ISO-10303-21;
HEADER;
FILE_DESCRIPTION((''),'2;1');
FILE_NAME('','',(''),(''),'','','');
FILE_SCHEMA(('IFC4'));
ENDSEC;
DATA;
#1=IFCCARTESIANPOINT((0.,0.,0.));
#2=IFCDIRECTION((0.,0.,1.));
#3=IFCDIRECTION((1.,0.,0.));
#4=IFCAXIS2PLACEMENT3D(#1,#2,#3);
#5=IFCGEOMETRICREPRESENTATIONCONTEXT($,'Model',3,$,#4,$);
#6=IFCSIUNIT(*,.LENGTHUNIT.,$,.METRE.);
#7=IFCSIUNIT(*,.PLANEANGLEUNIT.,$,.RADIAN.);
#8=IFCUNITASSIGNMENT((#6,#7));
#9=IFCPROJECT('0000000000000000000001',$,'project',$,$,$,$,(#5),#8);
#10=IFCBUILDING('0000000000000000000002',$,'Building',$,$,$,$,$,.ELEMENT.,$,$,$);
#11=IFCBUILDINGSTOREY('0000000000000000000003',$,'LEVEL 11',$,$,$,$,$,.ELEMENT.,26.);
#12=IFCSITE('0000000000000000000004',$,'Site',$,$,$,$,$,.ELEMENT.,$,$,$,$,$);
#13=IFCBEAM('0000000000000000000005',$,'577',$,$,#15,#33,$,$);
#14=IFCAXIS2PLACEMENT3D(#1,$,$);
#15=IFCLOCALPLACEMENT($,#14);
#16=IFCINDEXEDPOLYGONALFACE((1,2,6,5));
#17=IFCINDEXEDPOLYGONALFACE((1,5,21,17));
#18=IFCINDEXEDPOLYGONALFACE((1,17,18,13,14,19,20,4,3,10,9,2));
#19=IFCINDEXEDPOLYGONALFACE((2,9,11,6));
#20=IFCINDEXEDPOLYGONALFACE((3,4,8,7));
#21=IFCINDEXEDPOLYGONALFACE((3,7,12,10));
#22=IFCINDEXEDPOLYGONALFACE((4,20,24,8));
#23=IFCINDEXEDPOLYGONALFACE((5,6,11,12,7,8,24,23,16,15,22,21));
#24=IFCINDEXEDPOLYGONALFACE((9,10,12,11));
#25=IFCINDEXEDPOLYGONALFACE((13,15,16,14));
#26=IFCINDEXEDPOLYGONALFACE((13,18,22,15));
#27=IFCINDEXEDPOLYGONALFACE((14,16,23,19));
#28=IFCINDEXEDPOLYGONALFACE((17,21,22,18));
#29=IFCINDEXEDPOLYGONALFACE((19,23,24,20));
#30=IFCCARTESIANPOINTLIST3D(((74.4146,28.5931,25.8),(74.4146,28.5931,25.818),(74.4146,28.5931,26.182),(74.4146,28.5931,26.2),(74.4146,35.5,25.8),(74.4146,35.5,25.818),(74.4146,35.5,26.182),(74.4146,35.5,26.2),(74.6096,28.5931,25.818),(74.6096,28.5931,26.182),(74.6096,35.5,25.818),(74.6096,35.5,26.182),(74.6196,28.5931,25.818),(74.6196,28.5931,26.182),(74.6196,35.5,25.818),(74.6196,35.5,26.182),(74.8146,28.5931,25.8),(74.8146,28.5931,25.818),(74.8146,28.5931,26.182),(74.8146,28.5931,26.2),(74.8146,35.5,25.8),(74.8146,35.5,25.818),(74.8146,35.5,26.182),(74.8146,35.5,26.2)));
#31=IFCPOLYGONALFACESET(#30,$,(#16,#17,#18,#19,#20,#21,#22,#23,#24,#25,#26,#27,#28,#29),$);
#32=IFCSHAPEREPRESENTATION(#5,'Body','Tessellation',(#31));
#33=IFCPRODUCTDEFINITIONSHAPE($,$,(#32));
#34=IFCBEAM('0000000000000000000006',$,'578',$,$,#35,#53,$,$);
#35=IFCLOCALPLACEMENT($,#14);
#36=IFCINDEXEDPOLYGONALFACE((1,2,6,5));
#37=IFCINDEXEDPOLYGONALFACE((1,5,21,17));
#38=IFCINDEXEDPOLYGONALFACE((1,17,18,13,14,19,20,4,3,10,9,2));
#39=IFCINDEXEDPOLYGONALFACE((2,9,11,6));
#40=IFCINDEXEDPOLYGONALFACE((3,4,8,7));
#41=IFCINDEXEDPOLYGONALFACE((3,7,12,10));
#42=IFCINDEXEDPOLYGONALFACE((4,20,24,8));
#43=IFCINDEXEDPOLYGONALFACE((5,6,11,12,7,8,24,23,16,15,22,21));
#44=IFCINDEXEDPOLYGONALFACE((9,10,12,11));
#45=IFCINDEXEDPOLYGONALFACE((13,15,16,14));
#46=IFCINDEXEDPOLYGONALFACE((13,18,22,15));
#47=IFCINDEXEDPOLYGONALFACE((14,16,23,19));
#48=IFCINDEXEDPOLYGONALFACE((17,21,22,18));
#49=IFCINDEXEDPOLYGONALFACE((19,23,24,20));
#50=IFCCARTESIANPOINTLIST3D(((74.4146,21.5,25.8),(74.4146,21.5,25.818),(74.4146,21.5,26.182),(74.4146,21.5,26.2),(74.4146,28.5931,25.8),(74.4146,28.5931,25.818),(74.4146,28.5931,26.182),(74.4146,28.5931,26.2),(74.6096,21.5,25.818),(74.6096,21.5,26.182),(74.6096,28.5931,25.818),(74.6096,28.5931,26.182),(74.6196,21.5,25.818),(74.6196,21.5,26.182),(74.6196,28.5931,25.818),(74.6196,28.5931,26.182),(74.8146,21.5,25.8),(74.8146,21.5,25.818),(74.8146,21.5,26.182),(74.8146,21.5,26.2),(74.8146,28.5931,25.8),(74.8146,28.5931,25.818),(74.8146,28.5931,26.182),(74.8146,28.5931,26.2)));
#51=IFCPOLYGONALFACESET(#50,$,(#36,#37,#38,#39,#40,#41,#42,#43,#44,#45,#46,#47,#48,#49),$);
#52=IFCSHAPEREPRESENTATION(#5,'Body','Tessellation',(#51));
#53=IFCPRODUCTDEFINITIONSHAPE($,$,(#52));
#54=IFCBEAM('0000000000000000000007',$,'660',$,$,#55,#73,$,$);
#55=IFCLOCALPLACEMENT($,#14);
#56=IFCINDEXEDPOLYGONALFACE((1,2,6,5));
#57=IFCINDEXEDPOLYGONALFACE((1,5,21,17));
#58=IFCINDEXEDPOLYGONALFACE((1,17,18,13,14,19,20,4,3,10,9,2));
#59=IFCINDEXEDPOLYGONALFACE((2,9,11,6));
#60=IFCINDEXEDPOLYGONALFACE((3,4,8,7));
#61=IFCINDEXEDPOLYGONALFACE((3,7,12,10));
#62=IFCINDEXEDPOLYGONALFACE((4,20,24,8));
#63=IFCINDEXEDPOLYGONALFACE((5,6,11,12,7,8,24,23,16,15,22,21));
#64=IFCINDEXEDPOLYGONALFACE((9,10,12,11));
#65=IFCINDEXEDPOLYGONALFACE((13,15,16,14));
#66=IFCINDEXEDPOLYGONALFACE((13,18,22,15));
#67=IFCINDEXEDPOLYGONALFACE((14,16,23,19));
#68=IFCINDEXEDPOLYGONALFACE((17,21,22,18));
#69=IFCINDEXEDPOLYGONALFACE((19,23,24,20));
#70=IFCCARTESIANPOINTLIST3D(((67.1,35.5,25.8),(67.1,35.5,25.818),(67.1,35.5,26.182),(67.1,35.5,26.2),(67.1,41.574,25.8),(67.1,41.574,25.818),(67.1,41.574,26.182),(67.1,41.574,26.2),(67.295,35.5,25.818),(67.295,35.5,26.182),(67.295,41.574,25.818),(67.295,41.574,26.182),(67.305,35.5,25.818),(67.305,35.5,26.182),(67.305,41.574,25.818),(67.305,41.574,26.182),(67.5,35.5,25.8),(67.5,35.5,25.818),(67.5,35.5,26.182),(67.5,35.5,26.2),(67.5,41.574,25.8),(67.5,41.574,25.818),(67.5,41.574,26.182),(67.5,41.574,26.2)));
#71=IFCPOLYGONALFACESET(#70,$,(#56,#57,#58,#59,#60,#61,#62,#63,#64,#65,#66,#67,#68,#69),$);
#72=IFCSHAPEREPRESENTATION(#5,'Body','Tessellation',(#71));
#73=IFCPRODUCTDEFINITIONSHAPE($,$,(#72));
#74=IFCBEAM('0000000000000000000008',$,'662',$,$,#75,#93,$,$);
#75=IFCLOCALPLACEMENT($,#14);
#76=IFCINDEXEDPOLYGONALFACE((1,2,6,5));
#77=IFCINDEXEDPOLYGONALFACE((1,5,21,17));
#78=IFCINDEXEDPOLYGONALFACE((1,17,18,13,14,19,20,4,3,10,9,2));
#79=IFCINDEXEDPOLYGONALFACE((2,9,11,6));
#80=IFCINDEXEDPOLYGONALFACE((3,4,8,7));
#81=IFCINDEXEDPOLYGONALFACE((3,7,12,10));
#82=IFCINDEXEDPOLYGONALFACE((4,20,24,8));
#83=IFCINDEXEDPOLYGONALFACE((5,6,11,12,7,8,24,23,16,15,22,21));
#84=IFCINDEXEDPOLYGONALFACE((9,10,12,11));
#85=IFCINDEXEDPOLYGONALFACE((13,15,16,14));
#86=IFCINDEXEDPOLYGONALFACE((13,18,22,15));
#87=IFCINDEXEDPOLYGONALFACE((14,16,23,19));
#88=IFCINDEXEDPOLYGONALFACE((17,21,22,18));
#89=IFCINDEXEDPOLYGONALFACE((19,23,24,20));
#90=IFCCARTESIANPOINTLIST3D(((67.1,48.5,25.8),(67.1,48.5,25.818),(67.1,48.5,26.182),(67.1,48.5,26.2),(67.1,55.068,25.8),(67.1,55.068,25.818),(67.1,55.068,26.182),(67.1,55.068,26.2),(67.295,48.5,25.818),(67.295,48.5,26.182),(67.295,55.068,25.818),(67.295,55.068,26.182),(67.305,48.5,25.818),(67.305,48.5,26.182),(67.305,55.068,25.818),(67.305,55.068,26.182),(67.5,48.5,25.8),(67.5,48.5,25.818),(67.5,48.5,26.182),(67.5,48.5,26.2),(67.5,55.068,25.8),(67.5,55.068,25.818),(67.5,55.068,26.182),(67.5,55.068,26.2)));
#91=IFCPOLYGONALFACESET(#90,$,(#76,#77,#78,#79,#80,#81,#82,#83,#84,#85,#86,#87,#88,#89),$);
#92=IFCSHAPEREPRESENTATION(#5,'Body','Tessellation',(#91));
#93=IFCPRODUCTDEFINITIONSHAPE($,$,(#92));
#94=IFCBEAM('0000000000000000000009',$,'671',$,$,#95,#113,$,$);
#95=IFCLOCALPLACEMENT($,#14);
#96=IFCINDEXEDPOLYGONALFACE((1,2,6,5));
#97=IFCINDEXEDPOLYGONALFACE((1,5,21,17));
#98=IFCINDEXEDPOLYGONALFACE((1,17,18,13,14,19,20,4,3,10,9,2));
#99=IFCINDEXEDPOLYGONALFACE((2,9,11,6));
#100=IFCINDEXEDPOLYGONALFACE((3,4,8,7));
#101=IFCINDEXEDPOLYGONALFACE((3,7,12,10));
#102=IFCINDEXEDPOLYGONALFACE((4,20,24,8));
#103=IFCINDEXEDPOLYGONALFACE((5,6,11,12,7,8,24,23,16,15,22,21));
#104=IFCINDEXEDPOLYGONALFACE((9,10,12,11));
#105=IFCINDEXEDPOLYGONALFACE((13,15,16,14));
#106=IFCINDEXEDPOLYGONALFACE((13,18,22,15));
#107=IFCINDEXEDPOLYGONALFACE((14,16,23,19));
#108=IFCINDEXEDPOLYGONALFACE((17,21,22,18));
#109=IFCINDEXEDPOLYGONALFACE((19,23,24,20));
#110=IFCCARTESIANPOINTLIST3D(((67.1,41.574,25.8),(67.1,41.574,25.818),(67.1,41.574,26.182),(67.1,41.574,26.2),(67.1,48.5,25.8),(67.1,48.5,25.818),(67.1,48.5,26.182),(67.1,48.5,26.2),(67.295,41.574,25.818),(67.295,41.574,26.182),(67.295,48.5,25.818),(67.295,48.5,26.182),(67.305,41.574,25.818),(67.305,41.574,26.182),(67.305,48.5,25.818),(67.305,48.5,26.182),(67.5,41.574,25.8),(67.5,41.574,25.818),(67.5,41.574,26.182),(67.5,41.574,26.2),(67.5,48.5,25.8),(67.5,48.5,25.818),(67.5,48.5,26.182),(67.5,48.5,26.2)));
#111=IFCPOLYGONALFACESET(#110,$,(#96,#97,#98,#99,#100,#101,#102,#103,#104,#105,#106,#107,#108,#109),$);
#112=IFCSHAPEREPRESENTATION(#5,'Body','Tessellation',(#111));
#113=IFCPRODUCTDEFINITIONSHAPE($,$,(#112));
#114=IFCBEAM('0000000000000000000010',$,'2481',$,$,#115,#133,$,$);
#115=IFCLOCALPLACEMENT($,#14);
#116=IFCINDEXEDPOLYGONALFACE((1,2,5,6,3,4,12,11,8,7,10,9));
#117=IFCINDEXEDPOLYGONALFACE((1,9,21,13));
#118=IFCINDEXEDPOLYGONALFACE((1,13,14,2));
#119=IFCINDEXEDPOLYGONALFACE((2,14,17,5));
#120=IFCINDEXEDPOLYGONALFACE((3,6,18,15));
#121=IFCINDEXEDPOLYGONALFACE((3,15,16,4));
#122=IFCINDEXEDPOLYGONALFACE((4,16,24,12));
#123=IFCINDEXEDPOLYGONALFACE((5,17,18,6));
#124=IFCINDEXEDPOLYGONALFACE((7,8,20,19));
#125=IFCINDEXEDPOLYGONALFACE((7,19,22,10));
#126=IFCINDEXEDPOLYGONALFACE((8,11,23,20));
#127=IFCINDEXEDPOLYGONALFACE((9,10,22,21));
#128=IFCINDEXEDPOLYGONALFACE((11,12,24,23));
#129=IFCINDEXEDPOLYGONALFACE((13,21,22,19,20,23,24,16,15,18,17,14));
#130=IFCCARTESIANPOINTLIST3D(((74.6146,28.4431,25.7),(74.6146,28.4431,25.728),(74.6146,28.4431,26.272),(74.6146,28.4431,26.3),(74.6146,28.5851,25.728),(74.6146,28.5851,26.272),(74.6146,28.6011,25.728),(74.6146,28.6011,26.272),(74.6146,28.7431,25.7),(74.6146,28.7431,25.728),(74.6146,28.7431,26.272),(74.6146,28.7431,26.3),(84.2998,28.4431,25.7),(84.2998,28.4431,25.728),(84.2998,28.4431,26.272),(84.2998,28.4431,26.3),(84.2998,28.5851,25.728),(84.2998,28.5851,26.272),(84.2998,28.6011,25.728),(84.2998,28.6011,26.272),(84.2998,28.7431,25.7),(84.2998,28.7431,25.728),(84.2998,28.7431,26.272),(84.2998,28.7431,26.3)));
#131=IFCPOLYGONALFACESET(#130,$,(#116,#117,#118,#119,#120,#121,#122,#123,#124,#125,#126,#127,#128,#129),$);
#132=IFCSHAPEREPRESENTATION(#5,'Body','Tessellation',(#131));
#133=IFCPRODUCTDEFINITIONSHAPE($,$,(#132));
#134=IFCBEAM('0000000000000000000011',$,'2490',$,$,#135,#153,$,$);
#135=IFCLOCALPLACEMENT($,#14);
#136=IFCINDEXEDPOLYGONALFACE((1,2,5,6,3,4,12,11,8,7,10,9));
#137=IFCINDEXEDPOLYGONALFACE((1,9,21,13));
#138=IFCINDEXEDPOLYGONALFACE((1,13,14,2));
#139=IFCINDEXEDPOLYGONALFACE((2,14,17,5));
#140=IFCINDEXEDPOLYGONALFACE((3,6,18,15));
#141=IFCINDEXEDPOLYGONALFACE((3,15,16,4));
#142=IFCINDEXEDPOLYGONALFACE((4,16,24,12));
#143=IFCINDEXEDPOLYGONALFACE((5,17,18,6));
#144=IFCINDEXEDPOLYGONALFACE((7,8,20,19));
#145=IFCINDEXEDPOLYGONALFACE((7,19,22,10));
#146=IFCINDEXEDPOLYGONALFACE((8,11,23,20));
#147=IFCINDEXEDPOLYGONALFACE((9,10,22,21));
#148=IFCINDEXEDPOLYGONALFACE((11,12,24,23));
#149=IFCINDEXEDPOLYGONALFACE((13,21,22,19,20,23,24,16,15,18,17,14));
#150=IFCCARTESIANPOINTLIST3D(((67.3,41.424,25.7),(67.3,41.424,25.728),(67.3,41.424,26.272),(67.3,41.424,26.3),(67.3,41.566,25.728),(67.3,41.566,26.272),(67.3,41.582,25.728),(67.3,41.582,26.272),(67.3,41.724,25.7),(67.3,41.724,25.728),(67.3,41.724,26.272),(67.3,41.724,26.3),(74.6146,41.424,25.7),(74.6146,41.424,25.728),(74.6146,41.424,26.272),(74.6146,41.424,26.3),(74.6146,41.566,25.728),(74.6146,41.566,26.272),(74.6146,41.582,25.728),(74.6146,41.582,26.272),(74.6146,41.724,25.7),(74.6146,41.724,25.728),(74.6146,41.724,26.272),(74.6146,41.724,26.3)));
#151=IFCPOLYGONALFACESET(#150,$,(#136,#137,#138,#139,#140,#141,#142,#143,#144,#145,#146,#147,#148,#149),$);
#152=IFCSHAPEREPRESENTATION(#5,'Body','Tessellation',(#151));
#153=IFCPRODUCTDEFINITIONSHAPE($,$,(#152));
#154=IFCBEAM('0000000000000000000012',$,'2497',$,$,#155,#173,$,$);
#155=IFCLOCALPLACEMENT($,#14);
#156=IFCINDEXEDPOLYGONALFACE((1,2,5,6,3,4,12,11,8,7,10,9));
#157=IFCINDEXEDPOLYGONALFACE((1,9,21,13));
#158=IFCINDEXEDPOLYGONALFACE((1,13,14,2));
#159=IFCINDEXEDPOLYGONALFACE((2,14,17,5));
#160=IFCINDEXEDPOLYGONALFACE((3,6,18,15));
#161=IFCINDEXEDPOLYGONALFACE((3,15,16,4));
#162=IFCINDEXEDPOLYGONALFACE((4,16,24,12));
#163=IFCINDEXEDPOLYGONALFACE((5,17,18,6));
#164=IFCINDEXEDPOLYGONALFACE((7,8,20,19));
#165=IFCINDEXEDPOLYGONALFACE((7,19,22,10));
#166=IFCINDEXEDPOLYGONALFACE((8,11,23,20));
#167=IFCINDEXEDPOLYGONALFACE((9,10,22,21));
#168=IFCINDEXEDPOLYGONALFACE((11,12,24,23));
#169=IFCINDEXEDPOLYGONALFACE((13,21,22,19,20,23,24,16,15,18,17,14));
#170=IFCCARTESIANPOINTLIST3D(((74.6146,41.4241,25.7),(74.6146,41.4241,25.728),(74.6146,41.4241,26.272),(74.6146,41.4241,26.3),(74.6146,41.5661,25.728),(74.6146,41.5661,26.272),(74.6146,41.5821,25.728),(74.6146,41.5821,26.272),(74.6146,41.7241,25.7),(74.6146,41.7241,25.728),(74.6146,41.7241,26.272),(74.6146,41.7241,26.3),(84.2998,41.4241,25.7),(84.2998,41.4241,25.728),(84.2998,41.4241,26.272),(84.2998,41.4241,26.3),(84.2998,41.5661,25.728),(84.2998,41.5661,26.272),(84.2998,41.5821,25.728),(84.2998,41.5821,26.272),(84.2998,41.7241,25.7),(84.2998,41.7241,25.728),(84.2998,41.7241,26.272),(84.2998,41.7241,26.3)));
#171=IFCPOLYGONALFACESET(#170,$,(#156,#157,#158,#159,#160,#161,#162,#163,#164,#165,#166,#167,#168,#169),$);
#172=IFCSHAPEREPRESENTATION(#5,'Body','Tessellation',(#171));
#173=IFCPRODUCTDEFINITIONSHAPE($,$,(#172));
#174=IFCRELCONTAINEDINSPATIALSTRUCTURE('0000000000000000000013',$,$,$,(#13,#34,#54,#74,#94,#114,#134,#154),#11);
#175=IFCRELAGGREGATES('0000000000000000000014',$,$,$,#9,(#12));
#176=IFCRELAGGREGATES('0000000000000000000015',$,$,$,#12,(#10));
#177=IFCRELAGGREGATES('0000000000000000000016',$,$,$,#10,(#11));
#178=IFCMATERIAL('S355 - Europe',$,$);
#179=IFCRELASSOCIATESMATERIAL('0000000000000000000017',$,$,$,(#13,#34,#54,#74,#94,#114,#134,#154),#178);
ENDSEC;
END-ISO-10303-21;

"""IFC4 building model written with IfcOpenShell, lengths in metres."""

from ifc_helpers import new_model, si_unit, frame, origin_with_axes, origin_2d_with_axis, place, context, project, spatial, i_section, extrude, material, material_profile, profile_set, profile_usage, element, save


model = new_model("IFC4")

# Units and contexts
model_context = context("Model", 3, world=origin_with_axes())
ifc_project = project(units=[si_unit("LENGTHUNIT", "METRE"), si_unit("PLANEANGLEUNIT", "RADIAN")], contexts=[model_context])

# Site, building, storey
site = spatial("IfcSite", under=ifc_project, Name="Site", CompositionType="ELEMENT")
building = spatial("IfcBuilding", under=site, Name="Building", CompositionType="ELEMENT")
storey = spatial("IfcBuildingStorey", under=building, Name="LEVEL 11", CompositionType="ELEMENT", Elevation=26.0)

# Shared definitions
ifc_material = material(Name="S355 - Europe")

# Beams
ifc_material_profile_1 = material_profile(ifc_material, i_section(OverallWidth=0.4, OverallDepth=0.4, WebThickness=0.01, FlangeThickness=0.018, at=origin_2d_with_axis()))
ifc_profile_set_1 = profile_set([ifc_material_profile_1])
ifc_profile_usage_1 = profile_usage(ifc_profile_set_1, cardinal=10)
beam_1_placement = place(None, frame((74.6146, 35.5, 26.0), z_axis=(0.0, -1.0, 0.0), x_axis=(1.0, 0.0, 0.0)))
element("IfcBeam", 1, at=beam_1_placement, inside=storey, material=ifc_profile_usage_1, Name="577", context=model_context, shape_type="SweptSolid", body=[
    extrude(i_section(OverallWidth=0.4, OverallDepth=0.4, WebThickness=0.01, FlangeThickness=0.018, at=origin_2d_with_axis()), origin_with_axes(), (0.0, 0.0, 1.0), 6.9069),
])
ifc_material_profile_2 = material_profile(ifc_material, i_section(OverallWidth=0.4, OverallDepth=0.4, WebThickness=0.01, FlangeThickness=0.018, at=origin_2d_with_axis()))
ifc_profile_set_2 = profile_set([ifc_material_profile_2])
ifc_profile_usage_2 = profile_usage(ifc_profile_set_2, cardinal=10)
beam_2_placement = place(None, frame((74.6146, 28.5931, 26.0), z_axis=(0.0, -1.0, 0.0), x_axis=(1.0, 0.0, 0.0)))
element("IfcBeam", 2, at=beam_2_placement, inside=storey, material=ifc_profile_usage_2, Name="578", context=model_context, shape_type="SweptSolid", body=[
    extrude(i_section(OverallWidth=0.4, OverallDepth=0.4, WebThickness=0.01, FlangeThickness=0.018, at=origin_2d_with_axis()), origin_with_axes(), (0.0, 0.0, 1.0), 7.0931),
])
ifc_material_profile_3 = material_profile(ifc_material, i_section(OverallWidth=0.4, OverallDepth=0.4, WebThickness=0.01, FlangeThickness=0.018, at=origin_2d_with_axis()))
ifc_profile_set_3 = profile_set([ifc_material_profile_3])
ifc_profile_usage_3 = profile_usage(ifc_profile_set_3, cardinal=10)
beam_3_placement = place(None, frame((67.3, 35.5, 26.0), z_axis=(0.0, 1.0, 0.0), x_axis=(-1.0, 0.0, 0.0)))
element("IfcBeam", 3, at=beam_3_placement, inside=storey, material=ifc_profile_usage_3, Name="660", context=model_context, shape_type="SweptSolid", body=[
    extrude(i_section(OverallWidth=0.4, OverallDepth=0.4, WebThickness=0.01, FlangeThickness=0.018, at=origin_2d_with_axis()), origin_with_axes(), (0.0, 0.0, 1.0), 6.074),
])
ifc_material_profile_4 = material_profile(ifc_material, i_section(OverallWidth=0.4, OverallDepth=0.4, WebThickness=0.01, FlangeThickness=0.018, at=origin_2d_with_axis()))
ifc_profile_set_4 = profile_set([ifc_material_profile_4])
ifc_profile_usage_4 = profile_usage(ifc_profile_set_4, cardinal=10)
beam_4_placement = place(None, frame((67.3, 48.5, 26.0), z_axis=(0.0, 1.0, 0.0), x_axis=(-1.0, 0.0, 0.0)))
element("IfcBeam", 4, at=beam_4_placement, inside=storey, material=ifc_profile_usage_4, Name="662", context=model_context, shape_type="SweptSolid", body=[
    extrude(i_section(OverallWidth=0.4, OverallDepth=0.4, WebThickness=0.01, FlangeThickness=0.018, at=origin_2d_with_axis()), origin_with_axes(), (0.0, 0.0, 1.0), 6.568),
])
ifc_material_profile_5 = material_profile(ifc_material, i_section(OverallWidth=0.4, OverallDepth=0.4, WebThickness=0.01, FlangeThickness=0.018, at=origin_2d_with_axis()))
ifc_profile_set_5 = profile_set([ifc_material_profile_5])
ifc_profile_usage_5 = profile_usage(ifc_profile_set_5, cardinal=10)
beam_5_placement = place(None, frame((67.3, 41.574, 26.0), z_axis=(0.0, 1.0, 0.0), x_axis=(-1.0, 0.0, 0.0)))
element("IfcBeam", 5, at=beam_5_placement, inside=storey, material=ifc_profile_usage_5, Name="671", context=model_context, shape_type="SweptSolid", body=[
    extrude(i_section(OverallWidth=0.4, OverallDepth=0.4, WebThickness=0.01, FlangeThickness=0.018, at=origin_2d_with_axis()), origin_with_axes(), (0.0, 0.0, 1.0), 6.926),
])
ifc_material_profile_6 = material_profile(ifc_material, i_section(OverallWidth=0.3, OverallDepth=0.6, WebThickness=0.016, FlangeThickness=0.028, at=origin_2d_with_axis()))
ifc_profile_set_6 = profile_set([ifc_material_profile_6])
ifc_profile_usage_6 = profile_usage(ifc_profile_set_6, cardinal=10)
beam_6_placement = place(None, frame((74.6146, 28.5931, 26.0), z_axis=(1.0, 0.0, 0.0), x_axis=(0.0, 1.0, 0.0)))
element("IfcBeam", 6, at=beam_6_placement, inside=storey, material=ifc_profile_usage_6, Name="2481", context=model_context, shape_type="SweptSolid", body=[
    extrude(i_section(OverallWidth=0.3, OverallDepth=0.6, WebThickness=0.016, FlangeThickness=0.028, at=origin_2d_with_axis()), origin_with_axes(), (0.0, 0.0, 1.0), 9.6852),
])
ifc_material_profile_7 = material_profile(ifc_material, i_section(OverallWidth=0.3, OverallDepth=0.6, WebThickness=0.016, FlangeThickness=0.028, at=origin_2d_with_axis()))
ifc_profile_set_7 = profile_set([ifc_material_profile_7])
ifc_profile_usage_7 = profile_usage(ifc_profile_set_7, cardinal=10)
beam_7_placement = place(None, frame((67.3, 41.574, 26.0), z_axis=(1.0, 0.0, 0.0), x_axis=(0.0, 1.0, 0.0)))
element("IfcBeam", 7, at=beam_7_placement, inside=storey, material=ifc_profile_usage_7, Name="2490", context=model_context, shape_type="SweptSolid", body=[
    extrude(i_section(OverallWidth=0.3, OverallDepth=0.6, WebThickness=0.016, FlangeThickness=0.028, at=origin_2d_with_axis()), origin_with_axes(), (0.0, 0.0, 1.0), 7.3146),
])
ifc_material_profile_8 = material_profile(ifc_material, i_section(OverallWidth=0.3, OverallDepth=0.6, WebThickness=0.016, FlangeThickness=0.028, at=origin_2d_with_axis()))
ifc_profile_set_8 = profile_set([ifc_material_profile_8])
ifc_profile_usage_8 = profile_usage(ifc_profile_set_8, cardinal=10)
beam_8_placement = place(None, frame((74.6146, 41.5741, 26.0), z_axis=(1.0, 0.0, 0.0), x_axis=(0.0, 1.0, 0.0)))
element("IfcBeam", 8, at=beam_8_placement, inside=storey, material=ifc_profile_usage_8, Name="2497", context=model_context, shape_type="SweptSolid", body=[
    extrude(i_section(OverallWidth=0.3, OverallDepth=0.6, WebThickness=0.016, FlangeThickness=0.028, at=origin_2d_with_axis()), origin_with_axes(), (0.0, 0.0, 1.0), 9.6852),
])

save(model, "model.ifc")
